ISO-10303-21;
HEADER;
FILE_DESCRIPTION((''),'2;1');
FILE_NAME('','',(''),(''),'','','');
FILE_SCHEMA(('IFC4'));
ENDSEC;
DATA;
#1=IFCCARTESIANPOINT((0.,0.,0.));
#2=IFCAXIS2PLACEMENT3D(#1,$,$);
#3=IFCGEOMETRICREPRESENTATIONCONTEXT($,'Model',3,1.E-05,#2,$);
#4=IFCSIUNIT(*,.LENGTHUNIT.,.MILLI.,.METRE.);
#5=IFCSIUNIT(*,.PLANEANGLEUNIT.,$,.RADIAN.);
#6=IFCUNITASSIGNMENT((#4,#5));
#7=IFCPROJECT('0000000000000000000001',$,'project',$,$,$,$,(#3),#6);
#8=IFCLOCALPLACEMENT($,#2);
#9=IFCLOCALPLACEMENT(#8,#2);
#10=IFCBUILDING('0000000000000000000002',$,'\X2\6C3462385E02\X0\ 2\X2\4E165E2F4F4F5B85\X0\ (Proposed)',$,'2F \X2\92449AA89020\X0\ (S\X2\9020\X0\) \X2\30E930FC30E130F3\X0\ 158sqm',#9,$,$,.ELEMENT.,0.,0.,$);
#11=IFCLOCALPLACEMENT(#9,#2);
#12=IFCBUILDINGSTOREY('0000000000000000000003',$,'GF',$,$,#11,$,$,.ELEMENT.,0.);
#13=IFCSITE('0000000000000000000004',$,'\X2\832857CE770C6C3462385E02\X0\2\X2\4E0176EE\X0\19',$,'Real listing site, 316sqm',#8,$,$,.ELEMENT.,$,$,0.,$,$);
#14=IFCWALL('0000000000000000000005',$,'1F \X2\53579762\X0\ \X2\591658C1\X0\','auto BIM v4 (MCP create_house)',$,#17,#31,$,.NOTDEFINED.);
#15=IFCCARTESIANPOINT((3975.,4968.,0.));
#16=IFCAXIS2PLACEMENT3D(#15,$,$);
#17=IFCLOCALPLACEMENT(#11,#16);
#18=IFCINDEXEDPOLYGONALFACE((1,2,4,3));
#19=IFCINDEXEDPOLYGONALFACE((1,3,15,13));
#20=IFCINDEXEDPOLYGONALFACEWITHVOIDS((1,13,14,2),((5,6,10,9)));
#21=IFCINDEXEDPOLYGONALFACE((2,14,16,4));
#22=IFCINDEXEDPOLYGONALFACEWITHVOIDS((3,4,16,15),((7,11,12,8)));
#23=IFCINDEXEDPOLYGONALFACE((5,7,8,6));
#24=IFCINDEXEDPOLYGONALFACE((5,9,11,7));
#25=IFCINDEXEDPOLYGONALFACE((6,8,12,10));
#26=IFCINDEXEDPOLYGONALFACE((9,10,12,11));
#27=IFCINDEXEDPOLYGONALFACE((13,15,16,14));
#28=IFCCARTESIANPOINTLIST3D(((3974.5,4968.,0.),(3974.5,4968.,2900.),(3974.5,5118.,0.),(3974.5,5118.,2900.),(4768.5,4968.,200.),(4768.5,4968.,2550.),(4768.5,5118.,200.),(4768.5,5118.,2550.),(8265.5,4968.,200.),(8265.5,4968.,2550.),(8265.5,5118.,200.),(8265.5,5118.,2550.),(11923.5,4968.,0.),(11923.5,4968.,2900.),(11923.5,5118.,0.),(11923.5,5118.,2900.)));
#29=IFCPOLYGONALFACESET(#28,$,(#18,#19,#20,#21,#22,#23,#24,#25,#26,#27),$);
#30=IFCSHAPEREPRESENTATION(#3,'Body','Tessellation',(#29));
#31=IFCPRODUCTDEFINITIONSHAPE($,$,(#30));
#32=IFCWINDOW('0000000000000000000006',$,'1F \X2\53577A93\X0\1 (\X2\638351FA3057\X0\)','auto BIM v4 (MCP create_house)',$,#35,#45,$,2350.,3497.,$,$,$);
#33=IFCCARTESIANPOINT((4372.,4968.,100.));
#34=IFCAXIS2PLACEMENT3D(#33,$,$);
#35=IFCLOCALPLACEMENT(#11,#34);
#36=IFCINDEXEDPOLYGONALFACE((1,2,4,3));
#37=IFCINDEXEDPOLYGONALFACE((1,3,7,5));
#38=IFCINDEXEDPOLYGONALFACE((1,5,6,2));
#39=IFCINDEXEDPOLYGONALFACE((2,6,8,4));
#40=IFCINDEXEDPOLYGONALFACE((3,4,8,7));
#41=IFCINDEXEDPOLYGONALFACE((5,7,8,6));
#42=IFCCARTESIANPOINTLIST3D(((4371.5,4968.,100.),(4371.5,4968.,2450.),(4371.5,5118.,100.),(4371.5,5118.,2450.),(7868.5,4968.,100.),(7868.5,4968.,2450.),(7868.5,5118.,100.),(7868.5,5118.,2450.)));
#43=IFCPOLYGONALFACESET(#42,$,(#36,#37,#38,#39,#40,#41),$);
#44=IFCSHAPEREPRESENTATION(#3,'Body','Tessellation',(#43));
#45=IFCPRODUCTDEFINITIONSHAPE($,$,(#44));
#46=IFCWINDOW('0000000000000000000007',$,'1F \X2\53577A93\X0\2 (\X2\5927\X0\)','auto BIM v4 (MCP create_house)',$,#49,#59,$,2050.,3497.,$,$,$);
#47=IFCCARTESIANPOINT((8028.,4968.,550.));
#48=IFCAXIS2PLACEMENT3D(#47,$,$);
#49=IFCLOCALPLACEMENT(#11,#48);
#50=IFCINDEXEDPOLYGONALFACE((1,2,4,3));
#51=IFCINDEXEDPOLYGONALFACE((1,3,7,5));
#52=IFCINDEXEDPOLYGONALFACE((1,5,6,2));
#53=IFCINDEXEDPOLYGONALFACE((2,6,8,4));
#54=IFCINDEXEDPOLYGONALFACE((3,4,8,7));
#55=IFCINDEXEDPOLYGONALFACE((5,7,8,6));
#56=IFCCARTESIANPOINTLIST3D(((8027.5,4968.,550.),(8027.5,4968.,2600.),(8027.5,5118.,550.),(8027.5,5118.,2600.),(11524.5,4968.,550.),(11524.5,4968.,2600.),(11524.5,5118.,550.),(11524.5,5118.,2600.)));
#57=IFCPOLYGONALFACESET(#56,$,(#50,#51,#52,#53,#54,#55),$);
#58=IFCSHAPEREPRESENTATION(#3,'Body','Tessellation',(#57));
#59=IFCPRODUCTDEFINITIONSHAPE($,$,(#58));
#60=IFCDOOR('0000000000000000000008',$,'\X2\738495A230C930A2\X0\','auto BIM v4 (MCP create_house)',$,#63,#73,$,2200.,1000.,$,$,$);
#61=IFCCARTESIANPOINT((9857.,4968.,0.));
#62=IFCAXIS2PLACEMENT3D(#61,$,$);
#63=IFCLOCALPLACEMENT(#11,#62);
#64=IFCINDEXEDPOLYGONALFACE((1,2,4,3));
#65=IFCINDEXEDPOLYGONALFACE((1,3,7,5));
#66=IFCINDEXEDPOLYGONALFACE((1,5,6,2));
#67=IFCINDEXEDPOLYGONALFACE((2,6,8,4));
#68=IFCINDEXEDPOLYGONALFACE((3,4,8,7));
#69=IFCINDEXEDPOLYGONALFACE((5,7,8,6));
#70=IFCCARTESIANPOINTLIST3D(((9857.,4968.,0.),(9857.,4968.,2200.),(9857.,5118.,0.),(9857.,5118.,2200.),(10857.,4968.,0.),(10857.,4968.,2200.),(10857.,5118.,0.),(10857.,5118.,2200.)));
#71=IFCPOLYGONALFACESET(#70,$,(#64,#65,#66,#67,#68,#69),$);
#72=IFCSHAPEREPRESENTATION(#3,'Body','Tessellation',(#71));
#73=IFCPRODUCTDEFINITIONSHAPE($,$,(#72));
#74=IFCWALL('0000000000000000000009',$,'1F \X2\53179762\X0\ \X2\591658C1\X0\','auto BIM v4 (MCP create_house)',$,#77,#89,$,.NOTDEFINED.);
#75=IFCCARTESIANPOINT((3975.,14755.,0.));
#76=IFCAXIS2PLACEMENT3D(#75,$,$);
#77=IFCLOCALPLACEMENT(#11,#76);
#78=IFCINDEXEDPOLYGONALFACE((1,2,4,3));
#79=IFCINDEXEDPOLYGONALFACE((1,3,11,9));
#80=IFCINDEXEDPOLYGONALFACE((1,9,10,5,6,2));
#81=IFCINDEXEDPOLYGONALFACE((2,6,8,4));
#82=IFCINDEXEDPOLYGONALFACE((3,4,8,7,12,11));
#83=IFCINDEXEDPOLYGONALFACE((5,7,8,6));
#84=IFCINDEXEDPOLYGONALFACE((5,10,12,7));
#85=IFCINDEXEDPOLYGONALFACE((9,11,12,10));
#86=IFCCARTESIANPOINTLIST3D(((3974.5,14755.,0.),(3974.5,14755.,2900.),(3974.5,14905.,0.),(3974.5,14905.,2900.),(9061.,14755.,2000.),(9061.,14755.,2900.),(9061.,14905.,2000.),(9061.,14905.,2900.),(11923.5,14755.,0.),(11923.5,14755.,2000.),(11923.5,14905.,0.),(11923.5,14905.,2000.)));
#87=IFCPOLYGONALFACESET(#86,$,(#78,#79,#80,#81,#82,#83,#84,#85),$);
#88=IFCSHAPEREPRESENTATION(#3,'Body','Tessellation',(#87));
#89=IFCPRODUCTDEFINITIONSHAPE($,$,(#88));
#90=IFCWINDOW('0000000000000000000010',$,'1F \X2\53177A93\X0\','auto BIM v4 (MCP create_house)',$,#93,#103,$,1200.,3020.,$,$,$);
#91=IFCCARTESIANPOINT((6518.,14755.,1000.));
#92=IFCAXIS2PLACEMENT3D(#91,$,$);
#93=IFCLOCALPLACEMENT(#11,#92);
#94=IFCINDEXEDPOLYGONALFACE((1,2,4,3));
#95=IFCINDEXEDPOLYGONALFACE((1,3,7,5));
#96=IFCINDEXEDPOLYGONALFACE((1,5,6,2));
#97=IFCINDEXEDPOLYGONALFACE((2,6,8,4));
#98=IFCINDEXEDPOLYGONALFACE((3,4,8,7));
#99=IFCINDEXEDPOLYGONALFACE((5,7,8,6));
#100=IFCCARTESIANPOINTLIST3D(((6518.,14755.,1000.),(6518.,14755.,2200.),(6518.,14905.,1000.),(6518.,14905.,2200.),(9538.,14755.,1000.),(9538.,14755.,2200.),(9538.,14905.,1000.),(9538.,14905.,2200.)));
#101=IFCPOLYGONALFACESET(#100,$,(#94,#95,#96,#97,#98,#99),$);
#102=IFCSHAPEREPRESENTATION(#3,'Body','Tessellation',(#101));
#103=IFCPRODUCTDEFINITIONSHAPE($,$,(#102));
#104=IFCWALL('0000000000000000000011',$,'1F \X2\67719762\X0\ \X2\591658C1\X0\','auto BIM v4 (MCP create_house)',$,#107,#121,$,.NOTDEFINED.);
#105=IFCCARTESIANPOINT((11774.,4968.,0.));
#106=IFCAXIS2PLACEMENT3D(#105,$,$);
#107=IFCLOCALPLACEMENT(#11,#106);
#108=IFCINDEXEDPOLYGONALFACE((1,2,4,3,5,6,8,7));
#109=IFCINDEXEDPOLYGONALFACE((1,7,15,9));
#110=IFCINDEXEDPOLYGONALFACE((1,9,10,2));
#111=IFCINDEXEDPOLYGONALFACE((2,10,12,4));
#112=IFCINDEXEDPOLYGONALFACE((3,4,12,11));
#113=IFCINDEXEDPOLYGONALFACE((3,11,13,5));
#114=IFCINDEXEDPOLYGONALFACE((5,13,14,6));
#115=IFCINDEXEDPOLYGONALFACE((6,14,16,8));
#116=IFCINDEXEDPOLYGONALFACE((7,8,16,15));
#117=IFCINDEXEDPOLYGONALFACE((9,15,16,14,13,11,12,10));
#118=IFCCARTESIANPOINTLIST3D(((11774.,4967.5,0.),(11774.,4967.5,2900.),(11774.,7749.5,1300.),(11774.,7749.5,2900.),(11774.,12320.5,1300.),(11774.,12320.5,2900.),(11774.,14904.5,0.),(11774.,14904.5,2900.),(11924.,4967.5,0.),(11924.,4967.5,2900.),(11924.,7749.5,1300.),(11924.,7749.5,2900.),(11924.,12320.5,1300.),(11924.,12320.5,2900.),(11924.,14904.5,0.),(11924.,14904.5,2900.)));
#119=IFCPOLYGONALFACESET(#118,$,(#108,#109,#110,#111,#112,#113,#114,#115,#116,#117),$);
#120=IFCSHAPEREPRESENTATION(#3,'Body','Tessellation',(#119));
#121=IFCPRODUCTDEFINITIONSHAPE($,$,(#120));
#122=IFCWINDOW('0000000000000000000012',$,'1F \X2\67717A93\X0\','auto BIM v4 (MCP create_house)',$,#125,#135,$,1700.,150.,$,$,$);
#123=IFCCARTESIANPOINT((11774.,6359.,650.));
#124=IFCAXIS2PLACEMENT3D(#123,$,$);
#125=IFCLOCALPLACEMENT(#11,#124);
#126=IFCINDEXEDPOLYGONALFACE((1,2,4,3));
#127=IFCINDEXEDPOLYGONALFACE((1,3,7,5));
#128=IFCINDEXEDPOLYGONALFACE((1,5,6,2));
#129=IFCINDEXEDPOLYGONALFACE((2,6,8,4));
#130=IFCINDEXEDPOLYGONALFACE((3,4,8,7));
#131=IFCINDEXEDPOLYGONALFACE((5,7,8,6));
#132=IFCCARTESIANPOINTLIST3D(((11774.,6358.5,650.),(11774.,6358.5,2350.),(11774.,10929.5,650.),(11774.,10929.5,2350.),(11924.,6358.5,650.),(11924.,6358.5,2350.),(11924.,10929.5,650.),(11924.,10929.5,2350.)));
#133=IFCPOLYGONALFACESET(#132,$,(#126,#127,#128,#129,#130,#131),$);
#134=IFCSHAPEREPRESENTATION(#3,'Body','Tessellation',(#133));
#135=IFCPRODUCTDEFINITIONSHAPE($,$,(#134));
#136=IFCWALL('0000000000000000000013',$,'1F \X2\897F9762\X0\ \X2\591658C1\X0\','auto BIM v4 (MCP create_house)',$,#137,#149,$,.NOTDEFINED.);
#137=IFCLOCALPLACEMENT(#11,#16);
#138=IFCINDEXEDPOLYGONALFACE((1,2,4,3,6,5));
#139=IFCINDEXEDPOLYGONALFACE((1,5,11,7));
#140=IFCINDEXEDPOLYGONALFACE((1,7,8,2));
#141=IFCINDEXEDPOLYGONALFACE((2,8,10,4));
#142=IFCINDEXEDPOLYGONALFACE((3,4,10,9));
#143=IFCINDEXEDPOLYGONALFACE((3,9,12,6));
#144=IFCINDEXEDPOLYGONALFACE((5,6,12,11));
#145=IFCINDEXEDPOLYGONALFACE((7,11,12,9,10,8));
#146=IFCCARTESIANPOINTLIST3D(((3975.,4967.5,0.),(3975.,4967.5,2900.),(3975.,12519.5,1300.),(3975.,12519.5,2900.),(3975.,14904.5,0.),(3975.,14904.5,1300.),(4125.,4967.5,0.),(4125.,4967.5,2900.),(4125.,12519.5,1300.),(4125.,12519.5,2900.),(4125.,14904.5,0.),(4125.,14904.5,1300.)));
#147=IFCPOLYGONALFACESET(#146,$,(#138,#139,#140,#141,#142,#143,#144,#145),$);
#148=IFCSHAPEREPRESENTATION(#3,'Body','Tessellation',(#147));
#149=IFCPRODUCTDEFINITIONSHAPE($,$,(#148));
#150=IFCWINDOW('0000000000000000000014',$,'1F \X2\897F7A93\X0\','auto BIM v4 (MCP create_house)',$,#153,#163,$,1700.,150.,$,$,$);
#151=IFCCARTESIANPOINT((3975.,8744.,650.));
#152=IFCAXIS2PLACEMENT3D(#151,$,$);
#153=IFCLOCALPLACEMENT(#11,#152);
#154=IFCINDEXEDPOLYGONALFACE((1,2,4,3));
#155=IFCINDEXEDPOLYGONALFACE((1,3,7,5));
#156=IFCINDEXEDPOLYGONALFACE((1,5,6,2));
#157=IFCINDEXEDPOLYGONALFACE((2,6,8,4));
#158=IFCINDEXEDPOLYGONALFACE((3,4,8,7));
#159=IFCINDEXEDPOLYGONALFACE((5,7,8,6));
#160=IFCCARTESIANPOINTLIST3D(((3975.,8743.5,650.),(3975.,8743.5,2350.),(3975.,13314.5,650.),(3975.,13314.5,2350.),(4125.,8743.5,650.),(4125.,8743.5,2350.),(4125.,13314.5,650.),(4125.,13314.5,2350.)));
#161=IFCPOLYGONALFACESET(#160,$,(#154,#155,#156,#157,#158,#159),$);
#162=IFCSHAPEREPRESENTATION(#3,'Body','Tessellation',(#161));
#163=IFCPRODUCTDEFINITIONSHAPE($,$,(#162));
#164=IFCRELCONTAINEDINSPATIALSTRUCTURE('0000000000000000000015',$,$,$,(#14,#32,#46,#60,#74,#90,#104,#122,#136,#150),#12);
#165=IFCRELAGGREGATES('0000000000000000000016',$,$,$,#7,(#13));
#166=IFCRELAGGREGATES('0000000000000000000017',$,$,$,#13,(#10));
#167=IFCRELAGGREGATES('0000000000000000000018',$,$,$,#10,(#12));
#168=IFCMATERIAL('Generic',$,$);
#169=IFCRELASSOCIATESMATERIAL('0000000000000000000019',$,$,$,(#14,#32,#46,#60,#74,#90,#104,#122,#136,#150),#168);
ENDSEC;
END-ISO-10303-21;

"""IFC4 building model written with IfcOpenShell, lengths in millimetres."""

from ifc_helpers import new_model, si_unit, frame, frame_2d, origin, place, context, project, spatial, rectangle, extrude, material, element, fill, save


model = new_model("IFC4")

# Units and contexts
model_context = context("Model", 3, precision=1e-05, world=origin())
ifc_project = project(units=[si_unit("LENGTHUNIT", "METRE", prefix="MILLI"), si_unit("PLANEANGLEUNIT", "RADIAN")], contexts=[model_context])

# Site, building, storey
site_placement = place(None, origin())
site = spatial("IfcSite", under=ifc_project, at=site_placement, Name="茨城県水戸市2丁目19", ObjectType="Real listing site, 316sqm", CompositionType="ELEMENT", RefElevation=0.0)
building_placement = place(site_placement, origin())
building = spatial("IfcBuilding", under=site, at=building_placement, Name="水戸市 2世帯住宅 (Proposed)", ObjectType="2F 鉄骨造 (S造) ラーメン 158sqm", CompositionType="ELEMENT", ElevationOfRefHeight=0.0, ElevationOfTerrain=0.0)
storey_placement = place(building_placement, origin())
storey = spatial("IfcBuildingStorey", under=building, at=storey_placement, Name="GF", CompositionType="ELEMENT", Elevation=0.0)

# Shared definitions
ifc_material = material(Name="Generic")

# Wall, openings, windows, door
wall_1_placement = place(storey_placement, frame((3975.0, 4968.0, 0.0)))
wall_1 = element("IfcWall", 1, at=wall_1_placement, inside=storey, material=ifc_material, Name="1F 南面 外壁", Description="auto BIM v4 (MCP create_house)", PredefinedType="NOTDEFINED", context=model_context, shape_type="SweptSolid", body=[
    extrude(rectangle(XDim=7949.0, YDim=150.0, at=frame_2d((3974.0, 75.0))), frame((3975.0, 4968.0, 0.0)), (0.0, 0.0, 1.0), 2900.0),
])
opening_1_placement = place(storey_placement, frame((4372.0, 4968.0, 100.0)))
opening_1 = element("IfcOpeningElement", 2, at=opening_1_placement, cuts=wall_1, PredefinedType="NOTDEFINED", context=model_context, shape_type="SweptSolid", body=[
    extrude(rectangle(XDim=3497.0, YDim=150.0, at=frame_2d((1748.0, 75.0))), frame((4372.0, 4968.0, 100.0)), (0.0, 0.0, 1.0), 2350.0),
])
opening_2_placement = place(storey_placement, frame((8028.0, 4968.0, 550.0)))
opening_2 = element("IfcOpeningElement", 3, at=opening_2_placement, cuts=wall_1, PredefinedType="NOTDEFINED", context=model_context, shape_type="SweptSolid", body=[
    extrude(rectangle(XDim=3497.0, YDim=150.0, at=frame_2d((1748.0, 75.0))), frame((8028.0, 4968.0, 550.0)), (0.0, 0.0, 1.0), 2050.0),
])
opening_3_placement = place(storey_placement, frame((9857.0, 4968.0, 0.0)))
opening_3 = element("IfcOpeningElement", 4, at=opening_3_placement, cuts=wall_1, PredefinedType="NOTDEFINED", context=model_context, shape_type="SweptSolid", body=[
    extrude(rectangle(XDim=1000.0, YDim=150.0, at=frame_2d((500.0, 75.0))), frame((9857.0, 4968.0, 0.0)), (0.0, 0.0, 1.0), 2200.0),
])
window_1_placement = place(storey_placement, frame((4372.0, 4968.0, 100.0)))
window_1 = element("IfcWindow", 5, at=window_1_placement, inside=storey, material=ifc_material, Name="1F 南窓1 (掃出し)", Description="auto BIM v4 (MCP create_house)", OverallHeight=2350.0, OverallWidth=3497.0, context=model_context, shape_type="SweptSolid", body=[
    extrude(rectangle(XDim=3497.0, YDim=150.0, at=frame_2d((1748.0, 75.0))), frame((4372.0, 4968.0, 100.0)), (0.0, 0.0, 1.0), 2350.0),
])
fill(opening_1, window_1)
window_2_placement = place(storey_placement, frame((8028.0, 4968.0, 550.0)))
window_2 = element("IfcWindow", 6, at=window_2_placement, inside=storey, material=ifc_material, Name="1F 南窓2 (大)", Description="auto BIM v4 (MCP create_house)", OverallHeight=2050.0, OverallWidth=3497.0, context=model_context, shape_type="SweptSolid", body=[
    extrude(rectangle(XDim=3497.0, YDim=150.0, at=frame_2d((1748.0, 75.0))), frame((8028.0, 4968.0, 550.0)), (0.0, 0.0, 1.0), 2050.0),
])
fill(opening_2, window_2)
door_1_placement = place(storey_placement, frame((9857.0, 4968.0, 0.0)))
door_1 = element("IfcDoor", 7, at=door_1_placement, inside=storey, material=ifc_material, Name="玄関ドア", Description="auto BIM v4 (MCP create_house)", OverallHeight=2200.0, OverallWidth=1000.0, context=model_context, shape_type="SweptSolid", body=[
    extrude(rectangle(XDim=1000.0, YDim=150.0, at=frame_2d((500.0, 75.0))), frame((9857.0, 4968.0, 0.0)), (0.0, 0.0, 1.0), 2200.0),
])
fill(opening_3, door_1)

# Walls, openings, windows
wall_2_placement = place(storey_placement, frame((3975.0, 14755.0, 0.0)))
wall_2 = element("IfcWall", 8, at=wall_2_placement, inside=storey, material=ifc_material, Name="1F 北面 外壁", Description="auto BIM v4 (MCP create_house)", PredefinedType="NOTDEFINED", context=model_context, shape_type="SweptSolid", body=[
    extrude(rectangle(XDim=7949.0, YDim=150.0, at=frame_2d((3974.0, 75.0))), frame((3975.0, 14755.0, 0.0)), (0.0, 0.0, 1.0), 2900.0),
])
opening_4_placement = place(storey_placement, frame((6518.0, 14755.0, 1000.0)))
opening_4 = element("IfcOpeningElement", 9, at=opening_4_placement, cuts=wall_2, PredefinedType="NOTDEFINED", context=model_context, shape_type="SweptSolid", body=[
    extrude(rectangle(XDim=3020.0, YDim=150.0, at=frame_2d((1510.0, 75.0))), frame((6518.0, 14755.0, 1000.0)), (0.0, 0.0, 1.0), 1200.0),
])
window_3_placement = place(storey_placement, frame((6518.0, 14755.0, 1000.0)))
window_3 = element("IfcWindow", 10, at=window_3_placement, inside=storey, material=ifc_material, Name="1F 北窓", Description="auto BIM v4 (MCP create_house)", OverallHeight=1200.0, OverallWidth=3020.0, context=model_context, shape_type="SweptSolid", body=[
    extrude(rectangle(XDim=3020.0, YDim=150.0, at=frame_2d((1510.0, 75.0))), frame((6518.0, 14755.0, 1000.0)), (0.0, 0.0, 1.0), 1200.0),
])
fill(opening_4, window_3)
wall_3_placement = place(storey_placement, frame((11774.0, 4968.0, 0.0)))
wall_3 = element("IfcWall", 11, at=wall_3_placement, inside=storey, material=ifc_material, Name="1F 東面 外壁", Description="auto BIM v4 (MCP create_house)", PredefinedType="NOTDEFINED", context=model_context, shape_type="SweptSolid", body=[
    extrude(rectangle(XDim=150.0, YDim=9937.0, at=frame_2d((75.0, 4968.0))), frame((11774.0, 4968.0, 0.0)), (0.0, 0.0, 1.0), 2900.0),
])
opening_5_placement = place(storey_placement, frame((11774.0, 6359.0, 650.0)))
opening_5 = element("IfcOpeningElement", 12, at=opening_5_placement, cuts=wall_3, PredefinedType="NOTDEFINED", context=model_context, shape_type="SweptSolid", body=[
    extrude(rectangle(XDim=150.0, YDim=4571.0, at=frame_2d((75.0, 2285.0))), frame((11774.0, 6359.0, 650.0)), (0.0, 0.0, 1.0), 1700.0),
])
window_4_placement = place(storey_placement, frame((11774.0, 6359.0, 650.0)))
window_4 = element("IfcWindow", 13, at=window_4_placement, inside=storey, material=ifc_material, Name="1F 東窓", Description="auto BIM v4 (MCP create_house)", OverallHeight=1700.0, OverallWidth=150.0, context=model_context, shape_type="SweptSolid", body=[
    extrude(rectangle(XDim=150.0, YDim=4571.0, at=frame_2d((75.0, 2285.0))), frame((11774.0, 6359.0, 650.0)), (0.0, 0.0, 1.0), 1700.0),
])
fill(opening_5, window_4)
wall_4_placement = place(storey_placement, frame((3975.0, 4968.0, 0.0)))
wall_4 = element("IfcWall", 14, at=wall_4_placement, inside=storey, material=ifc_material, Name="1F 西面 外壁", Description="auto BIM v4 (MCP create_house)", PredefinedType="NOTDEFINED", context=model_context, shape_type="SweptSolid", body=[
    extrude(rectangle(XDim=150.0, YDim=9937.0, at=frame_2d((75.0, 4968.0))), frame((3975.0, 4968.0, 0.0)), (0.0, 0.0, 1.0), 2900.0),
])
opening_6_placement = place(storey_placement, frame((3975.0, 8744.0, 650.0)))
opening_6 = element("IfcOpeningElement", 15, at=opening_6_placement, cuts=wall_4, PredefinedType="NOTDEFINED", context=model_context, shape_type="SweptSolid", body=[
    extrude(rectangle(XDim=150.0, YDim=4571.0, at=frame_2d((75.0, 2285.0))), frame((3975.0, 8744.0, 650.0)), (0.0, 0.0, 1.0), 1700.0),
])
window_5_placement = place(storey_placement, frame((3975.0, 8744.0, 650.0)))
window_5 = element("IfcWindow", 16, at=window_5_placement, inside=storey, material=ifc_material, Name="1F 西窓", Description="auto BIM v4 (MCP create_house)", OverallHeight=1700.0, OverallWidth=150.0, context=model_context, shape_type="SweptSolid", body=[
    extrude(rectangle(XDim=150.0, YDim=4571.0, at=frame_2d((75.0, 2285.0))), frame((3975.0, 8744.0, 650.0)), (0.0, 0.0, 1.0), 1700.0),
])
fill(opening_6, window_5)

save(model, "model.ifc")
